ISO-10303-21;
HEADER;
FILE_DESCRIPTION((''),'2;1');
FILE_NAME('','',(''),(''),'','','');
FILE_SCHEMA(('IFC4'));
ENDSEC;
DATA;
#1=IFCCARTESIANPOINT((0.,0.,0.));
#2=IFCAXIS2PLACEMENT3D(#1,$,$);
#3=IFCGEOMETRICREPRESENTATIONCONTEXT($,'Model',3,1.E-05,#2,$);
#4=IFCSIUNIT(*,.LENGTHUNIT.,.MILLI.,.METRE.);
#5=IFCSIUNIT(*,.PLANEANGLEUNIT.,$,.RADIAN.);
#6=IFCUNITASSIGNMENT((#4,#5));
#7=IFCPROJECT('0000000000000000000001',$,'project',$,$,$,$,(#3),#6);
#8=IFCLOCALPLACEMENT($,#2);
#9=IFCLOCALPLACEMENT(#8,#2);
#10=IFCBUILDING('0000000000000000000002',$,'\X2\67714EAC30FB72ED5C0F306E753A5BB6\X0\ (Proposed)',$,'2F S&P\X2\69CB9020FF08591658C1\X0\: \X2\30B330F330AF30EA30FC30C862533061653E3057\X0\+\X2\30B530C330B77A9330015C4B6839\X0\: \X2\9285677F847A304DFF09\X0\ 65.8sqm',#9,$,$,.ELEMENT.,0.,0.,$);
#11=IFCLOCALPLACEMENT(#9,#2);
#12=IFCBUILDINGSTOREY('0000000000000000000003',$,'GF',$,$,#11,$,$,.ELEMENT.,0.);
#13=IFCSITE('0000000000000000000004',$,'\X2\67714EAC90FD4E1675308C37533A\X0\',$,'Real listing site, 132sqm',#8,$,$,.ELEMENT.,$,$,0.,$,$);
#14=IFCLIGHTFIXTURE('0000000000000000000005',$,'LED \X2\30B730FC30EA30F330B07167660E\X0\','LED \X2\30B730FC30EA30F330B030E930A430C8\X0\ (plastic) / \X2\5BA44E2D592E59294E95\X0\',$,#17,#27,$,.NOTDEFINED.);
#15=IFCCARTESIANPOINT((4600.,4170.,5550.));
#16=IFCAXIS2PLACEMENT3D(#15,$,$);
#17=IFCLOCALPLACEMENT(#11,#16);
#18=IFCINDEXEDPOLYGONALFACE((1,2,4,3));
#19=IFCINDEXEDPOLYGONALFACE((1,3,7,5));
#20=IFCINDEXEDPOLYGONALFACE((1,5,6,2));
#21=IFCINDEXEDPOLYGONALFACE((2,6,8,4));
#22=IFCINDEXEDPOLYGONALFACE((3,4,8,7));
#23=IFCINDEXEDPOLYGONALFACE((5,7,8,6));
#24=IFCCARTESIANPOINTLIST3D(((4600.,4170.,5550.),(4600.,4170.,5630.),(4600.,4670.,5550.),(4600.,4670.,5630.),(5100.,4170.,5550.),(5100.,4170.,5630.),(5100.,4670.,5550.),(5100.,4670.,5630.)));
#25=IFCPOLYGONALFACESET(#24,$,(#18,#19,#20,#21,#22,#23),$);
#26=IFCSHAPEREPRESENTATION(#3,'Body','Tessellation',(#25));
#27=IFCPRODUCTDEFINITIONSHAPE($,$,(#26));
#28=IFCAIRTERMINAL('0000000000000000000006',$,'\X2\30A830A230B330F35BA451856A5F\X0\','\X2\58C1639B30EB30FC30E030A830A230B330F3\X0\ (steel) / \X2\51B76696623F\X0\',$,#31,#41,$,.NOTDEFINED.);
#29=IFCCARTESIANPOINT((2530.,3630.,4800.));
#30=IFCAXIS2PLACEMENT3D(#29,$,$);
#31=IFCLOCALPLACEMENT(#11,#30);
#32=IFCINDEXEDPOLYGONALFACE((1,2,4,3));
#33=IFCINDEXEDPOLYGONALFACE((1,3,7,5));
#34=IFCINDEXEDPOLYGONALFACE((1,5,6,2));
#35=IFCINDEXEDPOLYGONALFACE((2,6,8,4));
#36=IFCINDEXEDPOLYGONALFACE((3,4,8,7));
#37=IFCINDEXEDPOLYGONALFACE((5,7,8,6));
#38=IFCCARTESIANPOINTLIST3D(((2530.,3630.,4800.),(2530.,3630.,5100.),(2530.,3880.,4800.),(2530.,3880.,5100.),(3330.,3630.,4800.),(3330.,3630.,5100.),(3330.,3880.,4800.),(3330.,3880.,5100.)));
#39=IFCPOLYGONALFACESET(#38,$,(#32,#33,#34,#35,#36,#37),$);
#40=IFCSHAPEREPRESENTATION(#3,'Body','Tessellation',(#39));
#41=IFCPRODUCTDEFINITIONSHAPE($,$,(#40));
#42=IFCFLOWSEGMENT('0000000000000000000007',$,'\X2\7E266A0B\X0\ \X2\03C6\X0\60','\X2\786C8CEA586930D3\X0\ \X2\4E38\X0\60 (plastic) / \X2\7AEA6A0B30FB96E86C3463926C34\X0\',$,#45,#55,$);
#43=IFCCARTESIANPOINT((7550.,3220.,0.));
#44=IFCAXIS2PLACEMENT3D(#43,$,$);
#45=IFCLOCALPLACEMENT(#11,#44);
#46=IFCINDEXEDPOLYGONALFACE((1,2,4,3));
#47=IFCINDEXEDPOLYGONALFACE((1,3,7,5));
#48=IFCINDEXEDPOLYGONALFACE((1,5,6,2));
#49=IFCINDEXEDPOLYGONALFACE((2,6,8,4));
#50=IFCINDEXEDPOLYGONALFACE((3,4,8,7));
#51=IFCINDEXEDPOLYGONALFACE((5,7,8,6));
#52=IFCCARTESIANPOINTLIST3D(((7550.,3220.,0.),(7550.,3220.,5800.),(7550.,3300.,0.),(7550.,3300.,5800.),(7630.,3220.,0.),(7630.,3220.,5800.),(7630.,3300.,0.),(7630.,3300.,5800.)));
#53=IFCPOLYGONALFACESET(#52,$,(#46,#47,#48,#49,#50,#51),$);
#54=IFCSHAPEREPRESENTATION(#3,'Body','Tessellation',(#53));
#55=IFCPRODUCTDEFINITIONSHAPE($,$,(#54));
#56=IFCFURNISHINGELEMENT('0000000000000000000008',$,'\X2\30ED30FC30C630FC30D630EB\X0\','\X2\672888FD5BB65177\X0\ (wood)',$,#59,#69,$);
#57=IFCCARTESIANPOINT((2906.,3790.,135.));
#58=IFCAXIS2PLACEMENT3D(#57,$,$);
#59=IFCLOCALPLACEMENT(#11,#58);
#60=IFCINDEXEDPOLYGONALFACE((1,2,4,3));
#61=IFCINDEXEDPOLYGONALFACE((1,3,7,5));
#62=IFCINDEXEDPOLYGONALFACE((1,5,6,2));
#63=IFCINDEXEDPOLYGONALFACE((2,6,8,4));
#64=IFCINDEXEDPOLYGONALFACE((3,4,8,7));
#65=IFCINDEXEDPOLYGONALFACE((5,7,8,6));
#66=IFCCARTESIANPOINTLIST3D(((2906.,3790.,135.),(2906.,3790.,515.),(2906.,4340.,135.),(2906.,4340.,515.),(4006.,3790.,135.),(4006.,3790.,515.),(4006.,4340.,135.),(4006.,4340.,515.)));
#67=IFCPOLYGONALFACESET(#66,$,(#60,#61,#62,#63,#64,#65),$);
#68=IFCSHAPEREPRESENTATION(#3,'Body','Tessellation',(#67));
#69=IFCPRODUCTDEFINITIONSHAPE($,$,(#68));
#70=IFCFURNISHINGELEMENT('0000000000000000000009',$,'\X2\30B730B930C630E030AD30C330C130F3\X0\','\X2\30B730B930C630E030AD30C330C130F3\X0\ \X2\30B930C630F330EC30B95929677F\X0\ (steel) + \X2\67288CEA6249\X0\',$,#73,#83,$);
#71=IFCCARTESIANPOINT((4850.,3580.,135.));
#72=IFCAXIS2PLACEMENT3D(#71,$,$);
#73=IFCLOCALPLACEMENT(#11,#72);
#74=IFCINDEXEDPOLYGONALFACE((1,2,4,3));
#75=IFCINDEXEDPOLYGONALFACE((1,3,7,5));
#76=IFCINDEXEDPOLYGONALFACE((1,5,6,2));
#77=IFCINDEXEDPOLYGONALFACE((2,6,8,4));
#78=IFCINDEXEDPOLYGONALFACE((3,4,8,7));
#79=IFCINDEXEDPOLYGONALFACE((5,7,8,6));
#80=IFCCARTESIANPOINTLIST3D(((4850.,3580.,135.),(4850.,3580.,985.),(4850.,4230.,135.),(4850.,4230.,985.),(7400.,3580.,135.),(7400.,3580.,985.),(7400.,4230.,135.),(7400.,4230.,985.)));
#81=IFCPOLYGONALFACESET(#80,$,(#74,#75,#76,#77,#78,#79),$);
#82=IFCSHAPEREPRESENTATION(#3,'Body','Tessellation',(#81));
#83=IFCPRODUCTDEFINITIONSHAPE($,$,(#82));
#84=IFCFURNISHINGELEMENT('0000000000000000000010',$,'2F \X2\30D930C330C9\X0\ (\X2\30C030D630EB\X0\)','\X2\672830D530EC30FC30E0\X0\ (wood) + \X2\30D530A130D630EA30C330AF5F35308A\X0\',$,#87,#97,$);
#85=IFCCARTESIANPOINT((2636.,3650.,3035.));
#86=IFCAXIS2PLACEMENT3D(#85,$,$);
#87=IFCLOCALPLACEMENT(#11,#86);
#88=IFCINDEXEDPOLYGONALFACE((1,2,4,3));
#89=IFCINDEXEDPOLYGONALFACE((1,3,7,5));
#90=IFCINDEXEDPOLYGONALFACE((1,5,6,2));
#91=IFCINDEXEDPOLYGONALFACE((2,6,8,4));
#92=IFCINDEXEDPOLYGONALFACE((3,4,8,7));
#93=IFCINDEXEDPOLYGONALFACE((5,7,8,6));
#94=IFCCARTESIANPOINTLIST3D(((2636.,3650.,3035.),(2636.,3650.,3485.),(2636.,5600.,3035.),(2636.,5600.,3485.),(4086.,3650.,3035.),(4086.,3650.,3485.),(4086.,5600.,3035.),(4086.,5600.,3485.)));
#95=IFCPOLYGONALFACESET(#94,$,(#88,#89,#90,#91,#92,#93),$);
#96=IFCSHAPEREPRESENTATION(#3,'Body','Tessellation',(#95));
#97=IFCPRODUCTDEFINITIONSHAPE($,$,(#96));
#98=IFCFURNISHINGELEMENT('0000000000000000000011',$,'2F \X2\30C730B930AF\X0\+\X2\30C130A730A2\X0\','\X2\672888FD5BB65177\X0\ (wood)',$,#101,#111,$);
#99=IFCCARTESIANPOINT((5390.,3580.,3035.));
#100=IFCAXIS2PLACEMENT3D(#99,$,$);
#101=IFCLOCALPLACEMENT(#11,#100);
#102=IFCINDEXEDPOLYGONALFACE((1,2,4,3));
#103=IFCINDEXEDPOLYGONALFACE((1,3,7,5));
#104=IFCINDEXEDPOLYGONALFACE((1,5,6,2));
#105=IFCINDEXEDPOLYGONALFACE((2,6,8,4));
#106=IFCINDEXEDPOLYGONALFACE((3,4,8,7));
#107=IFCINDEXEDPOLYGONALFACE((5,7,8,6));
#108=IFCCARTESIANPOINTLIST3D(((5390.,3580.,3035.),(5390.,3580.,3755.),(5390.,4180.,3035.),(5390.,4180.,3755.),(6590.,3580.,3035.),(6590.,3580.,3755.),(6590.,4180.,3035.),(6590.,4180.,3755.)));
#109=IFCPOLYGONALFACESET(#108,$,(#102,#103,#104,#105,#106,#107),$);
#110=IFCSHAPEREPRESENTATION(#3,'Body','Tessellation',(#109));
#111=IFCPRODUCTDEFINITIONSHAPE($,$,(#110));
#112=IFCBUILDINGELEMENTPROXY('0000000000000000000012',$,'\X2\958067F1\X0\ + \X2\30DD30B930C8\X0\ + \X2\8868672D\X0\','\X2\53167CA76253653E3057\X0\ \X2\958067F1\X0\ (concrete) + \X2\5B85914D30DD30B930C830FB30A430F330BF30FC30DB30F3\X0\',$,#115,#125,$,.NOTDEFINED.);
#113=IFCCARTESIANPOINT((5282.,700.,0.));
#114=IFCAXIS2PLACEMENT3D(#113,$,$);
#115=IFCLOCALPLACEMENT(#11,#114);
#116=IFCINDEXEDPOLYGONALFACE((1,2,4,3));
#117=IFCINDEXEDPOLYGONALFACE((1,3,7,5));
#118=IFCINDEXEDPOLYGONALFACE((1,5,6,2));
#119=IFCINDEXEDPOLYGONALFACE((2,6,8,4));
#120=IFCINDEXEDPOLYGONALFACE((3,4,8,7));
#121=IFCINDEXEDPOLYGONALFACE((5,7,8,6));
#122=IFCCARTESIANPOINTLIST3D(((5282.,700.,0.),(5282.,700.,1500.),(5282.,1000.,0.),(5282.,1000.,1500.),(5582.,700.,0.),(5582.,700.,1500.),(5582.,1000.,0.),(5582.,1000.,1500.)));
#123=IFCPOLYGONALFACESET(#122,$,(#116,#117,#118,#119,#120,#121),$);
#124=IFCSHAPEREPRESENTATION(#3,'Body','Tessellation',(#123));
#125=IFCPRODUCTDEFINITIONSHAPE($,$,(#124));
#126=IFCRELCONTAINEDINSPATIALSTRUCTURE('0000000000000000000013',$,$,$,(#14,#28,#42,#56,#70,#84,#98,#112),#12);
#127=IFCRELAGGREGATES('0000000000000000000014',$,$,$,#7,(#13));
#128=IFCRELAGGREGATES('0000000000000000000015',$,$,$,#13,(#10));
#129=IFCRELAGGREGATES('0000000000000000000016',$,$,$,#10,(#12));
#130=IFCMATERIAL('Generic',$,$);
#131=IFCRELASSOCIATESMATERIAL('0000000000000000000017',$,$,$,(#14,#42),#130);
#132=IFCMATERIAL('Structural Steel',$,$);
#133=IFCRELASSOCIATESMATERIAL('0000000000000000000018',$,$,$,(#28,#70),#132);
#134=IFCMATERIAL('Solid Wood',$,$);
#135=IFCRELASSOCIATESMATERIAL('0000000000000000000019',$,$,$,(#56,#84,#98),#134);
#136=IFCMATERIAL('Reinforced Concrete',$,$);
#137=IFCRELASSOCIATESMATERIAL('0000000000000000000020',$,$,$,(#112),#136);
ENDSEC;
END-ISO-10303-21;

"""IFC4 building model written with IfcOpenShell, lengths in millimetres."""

from ifc_helpers import new_model, si_unit, frame, frame_2d, origin, place, context, project, spatial, rectangle, extrude, material, element, save


model = new_model("IFC4")

# Units and contexts
model_context = context("Model", 3, precision=1e-05, world=origin())
ifc_project = project(units=[si_unit("LENGTHUNIT", "METRE", prefix="MILLI"), si_unit("PLANEANGLEUNIT", "RADIAN")], contexts=[model_context])

# Site, building, storey
site_placement = place(None, origin())
site = spatial("IfcSite", under=ifc_project, at=site_placement, Name="東京都世田谷区", ObjectType="Real listing site, 132sqm", CompositionType="ELEMENT", RefElevation=0.0)
building_placement = place(site_placement, origin())
building = spatial("IfcBuilding", under=site, at=building_placement, Name="東京・狭小の町家 (Proposed)", ObjectType="2F S&P構造（外壁: コンクリート打ち放し+サッシ窓、屋根: 銅板葺き） 65.8sqm", CompositionType="ELEMENT", ElevationOfRefHeight=0.0, ElevationOfTerrain=0.0)
storey_placement = place(building_placement, origin())
storey = spatial("IfcBuildingStorey", under=building, at=storey_placement, Name="GF", CompositionType="ELEMENT", Elevation=0.0)

# Shared definitions
ifc_material_1 = material(Name="Solid Wood")

# Shared definitions
ifc_material_2 = material(Name="Reinforced Concrete")

# Shared definitions
ifc_material_3 = material(Name="Structural Steel")

# Shared definitions
ifc_material_4 = material(Name="Generic")

# Light fixture
light_fixture_1_placement = place(storey_placement, frame((4600.0, 4170.0, 5550.0)))
element("IfcLightFixture", 1, at=light_fixture_1_placement, inside=storey, material=ifc_material_4, Name="LED シーリング照明", Description="LED シーリングライト (plastic) / 室中央天井", PredefinedType="NOTDEFINED", context=model_context, shape_type="SweptSolid", body=[
    extrude(rectangle(XDim=500.0, YDim=500.0, at=frame_2d((250.0, 250.0))), frame((4600.0, 4170.0, 5550.0)), (0.0, 0.0, 1.0), 80.0),
])

# Air terminal
air_terminal_placement = place(storey_placement, frame((2530.0, 3630.0, 4800.0)))
element("IfcAirTerminal", 2, at=air_terminal_placement, inside=storey, material=ifc_material_3, Name="エアコン室内機", Description="壁掛ルームエアコン (steel) / 冷暖房", PredefinedType="NOTDEFINED", context=model_context, shape_type="SweptSolid", body=[
    extrude(rectangle(XDim=800.0, YDim=250.0, at=frame_2d((400.0, 125.0))), frame((2530.0, 3630.0, 4800.0)), (0.0, 0.0, 1.0), 300.0),
])

# Flow segment
flow_segment_placement = place(storey_placement, frame((7550.0, 3220.0, 0.0)))
element("IfcFlowSegment", 3, at=flow_segment_placement, inside=storey, material=ifc_material_4, Name="縦樋 φ60", Description="硬質塩ビ 丸60 (plastic) / 竪樋・雨水排水", context=model_context, shape_type="SweptSolid", body=[
    extrude(rectangle(XDim=80.0, YDim=80.0, at=frame_2d((40.0, 40.0))), frame((7550.0, 3220.0, 0.0)), (0.0, 0.0, 1.0), 5800.0),
])

# Furnishing elements
furnishing_1_placement = place(storey_placement, frame((2906.0, 3790.0, 135.0)))
element("IfcFurnishingElement", 4, at=furnishing_1_placement, inside=storey, material=ifc_material_1, Name="ローテーブル", Description="木製家具 (wood)", context=model_context, shape_type="SweptSolid", body=[
    extrude(rectangle(XDim=1100.0, YDim=550.0, at=frame_2d((550.0, 275.0))), frame((2906.0, 3790.0, 135.0)), (0.0, 0.0, 1.0), 380.0),
])
furnishing_2_placement = place(storey_placement, frame((4850.0, 3580.0, 135.0)))
element("IfcFurnishingElement", 5, at=furnishing_2_placement, inside=storey, material=ifc_material_3, Name="システムキッチン", Description="システムキッチン ステンレス天板 (steel) + 木質扉", context=model_context, shape_type="SweptSolid", body=[
    extrude(rectangle(XDim=2550.0, YDim=650.0, at=frame_2d((1275.0, 325.0))), frame((4850.0, 3580.0, 135.0)), (0.0, 0.0, 1.0), 850.0),
])
furnishing_3_placement = place(storey_placement, frame((2636.0, 3650.0, 3035.0)))
element("IfcFurnishingElement", 6, at=furnishing_3_placement, inside=storey, material=ifc_material_1, Name="2F ベッド (ダブル)", Description="木フレーム (wood) + ファブリック張り", context=model_context, shape_type="SweptSolid", body=[
    extrude(rectangle(XDim=1450.0, YDim=1950.0, at=frame_2d((725.0, 975.0))), frame((2636.0, 3650.0, 3035.0)), (0.0, 0.0, 1.0), 450.0),
])
furnishing_4_placement = place(storey_placement, frame((5390.0, 3580.0, 3035.0)))
element("IfcFurnishingElement", 7, at=furnishing_4_placement, inside=storey, material=ifc_material_1, Name="2F デスク+チェア", Description="木製家具 (wood)", context=model_context, shape_type="SweptSolid", body=[
    extrude(rectangle(XDim=1200.0, YDim=600.0, at=frame_2d((600.0, 300.0))), frame((5390.0, 3580.0, 3035.0)), (0.0, 0.0, 1.0), 720.0),
])

# Building element proxy
proxy_placement = place(storey_placement, frame((5282.0, 700.0, 0.0)))
element("IfcBuildingElementProxy", 8, at=proxy_placement, inside=storey, material=ifc_material_2, Name="門柱 + ポスト + 表札", Description="化粧打放し 門柱 (concrete) + 宅配ポスト・インターホン", PredefinedType="NOTDEFINED", context=model_context, shape_type="SweptSolid", body=[
    extrude(rectangle(XDim=300.0, YDim=300.0, at=frame_2d((150.0, 150.0))), frame((5282.0, 700.0, 0.0)), (0.0, 0.0, 1.0), 1500.0),
])

save(model, "model.ifc")
